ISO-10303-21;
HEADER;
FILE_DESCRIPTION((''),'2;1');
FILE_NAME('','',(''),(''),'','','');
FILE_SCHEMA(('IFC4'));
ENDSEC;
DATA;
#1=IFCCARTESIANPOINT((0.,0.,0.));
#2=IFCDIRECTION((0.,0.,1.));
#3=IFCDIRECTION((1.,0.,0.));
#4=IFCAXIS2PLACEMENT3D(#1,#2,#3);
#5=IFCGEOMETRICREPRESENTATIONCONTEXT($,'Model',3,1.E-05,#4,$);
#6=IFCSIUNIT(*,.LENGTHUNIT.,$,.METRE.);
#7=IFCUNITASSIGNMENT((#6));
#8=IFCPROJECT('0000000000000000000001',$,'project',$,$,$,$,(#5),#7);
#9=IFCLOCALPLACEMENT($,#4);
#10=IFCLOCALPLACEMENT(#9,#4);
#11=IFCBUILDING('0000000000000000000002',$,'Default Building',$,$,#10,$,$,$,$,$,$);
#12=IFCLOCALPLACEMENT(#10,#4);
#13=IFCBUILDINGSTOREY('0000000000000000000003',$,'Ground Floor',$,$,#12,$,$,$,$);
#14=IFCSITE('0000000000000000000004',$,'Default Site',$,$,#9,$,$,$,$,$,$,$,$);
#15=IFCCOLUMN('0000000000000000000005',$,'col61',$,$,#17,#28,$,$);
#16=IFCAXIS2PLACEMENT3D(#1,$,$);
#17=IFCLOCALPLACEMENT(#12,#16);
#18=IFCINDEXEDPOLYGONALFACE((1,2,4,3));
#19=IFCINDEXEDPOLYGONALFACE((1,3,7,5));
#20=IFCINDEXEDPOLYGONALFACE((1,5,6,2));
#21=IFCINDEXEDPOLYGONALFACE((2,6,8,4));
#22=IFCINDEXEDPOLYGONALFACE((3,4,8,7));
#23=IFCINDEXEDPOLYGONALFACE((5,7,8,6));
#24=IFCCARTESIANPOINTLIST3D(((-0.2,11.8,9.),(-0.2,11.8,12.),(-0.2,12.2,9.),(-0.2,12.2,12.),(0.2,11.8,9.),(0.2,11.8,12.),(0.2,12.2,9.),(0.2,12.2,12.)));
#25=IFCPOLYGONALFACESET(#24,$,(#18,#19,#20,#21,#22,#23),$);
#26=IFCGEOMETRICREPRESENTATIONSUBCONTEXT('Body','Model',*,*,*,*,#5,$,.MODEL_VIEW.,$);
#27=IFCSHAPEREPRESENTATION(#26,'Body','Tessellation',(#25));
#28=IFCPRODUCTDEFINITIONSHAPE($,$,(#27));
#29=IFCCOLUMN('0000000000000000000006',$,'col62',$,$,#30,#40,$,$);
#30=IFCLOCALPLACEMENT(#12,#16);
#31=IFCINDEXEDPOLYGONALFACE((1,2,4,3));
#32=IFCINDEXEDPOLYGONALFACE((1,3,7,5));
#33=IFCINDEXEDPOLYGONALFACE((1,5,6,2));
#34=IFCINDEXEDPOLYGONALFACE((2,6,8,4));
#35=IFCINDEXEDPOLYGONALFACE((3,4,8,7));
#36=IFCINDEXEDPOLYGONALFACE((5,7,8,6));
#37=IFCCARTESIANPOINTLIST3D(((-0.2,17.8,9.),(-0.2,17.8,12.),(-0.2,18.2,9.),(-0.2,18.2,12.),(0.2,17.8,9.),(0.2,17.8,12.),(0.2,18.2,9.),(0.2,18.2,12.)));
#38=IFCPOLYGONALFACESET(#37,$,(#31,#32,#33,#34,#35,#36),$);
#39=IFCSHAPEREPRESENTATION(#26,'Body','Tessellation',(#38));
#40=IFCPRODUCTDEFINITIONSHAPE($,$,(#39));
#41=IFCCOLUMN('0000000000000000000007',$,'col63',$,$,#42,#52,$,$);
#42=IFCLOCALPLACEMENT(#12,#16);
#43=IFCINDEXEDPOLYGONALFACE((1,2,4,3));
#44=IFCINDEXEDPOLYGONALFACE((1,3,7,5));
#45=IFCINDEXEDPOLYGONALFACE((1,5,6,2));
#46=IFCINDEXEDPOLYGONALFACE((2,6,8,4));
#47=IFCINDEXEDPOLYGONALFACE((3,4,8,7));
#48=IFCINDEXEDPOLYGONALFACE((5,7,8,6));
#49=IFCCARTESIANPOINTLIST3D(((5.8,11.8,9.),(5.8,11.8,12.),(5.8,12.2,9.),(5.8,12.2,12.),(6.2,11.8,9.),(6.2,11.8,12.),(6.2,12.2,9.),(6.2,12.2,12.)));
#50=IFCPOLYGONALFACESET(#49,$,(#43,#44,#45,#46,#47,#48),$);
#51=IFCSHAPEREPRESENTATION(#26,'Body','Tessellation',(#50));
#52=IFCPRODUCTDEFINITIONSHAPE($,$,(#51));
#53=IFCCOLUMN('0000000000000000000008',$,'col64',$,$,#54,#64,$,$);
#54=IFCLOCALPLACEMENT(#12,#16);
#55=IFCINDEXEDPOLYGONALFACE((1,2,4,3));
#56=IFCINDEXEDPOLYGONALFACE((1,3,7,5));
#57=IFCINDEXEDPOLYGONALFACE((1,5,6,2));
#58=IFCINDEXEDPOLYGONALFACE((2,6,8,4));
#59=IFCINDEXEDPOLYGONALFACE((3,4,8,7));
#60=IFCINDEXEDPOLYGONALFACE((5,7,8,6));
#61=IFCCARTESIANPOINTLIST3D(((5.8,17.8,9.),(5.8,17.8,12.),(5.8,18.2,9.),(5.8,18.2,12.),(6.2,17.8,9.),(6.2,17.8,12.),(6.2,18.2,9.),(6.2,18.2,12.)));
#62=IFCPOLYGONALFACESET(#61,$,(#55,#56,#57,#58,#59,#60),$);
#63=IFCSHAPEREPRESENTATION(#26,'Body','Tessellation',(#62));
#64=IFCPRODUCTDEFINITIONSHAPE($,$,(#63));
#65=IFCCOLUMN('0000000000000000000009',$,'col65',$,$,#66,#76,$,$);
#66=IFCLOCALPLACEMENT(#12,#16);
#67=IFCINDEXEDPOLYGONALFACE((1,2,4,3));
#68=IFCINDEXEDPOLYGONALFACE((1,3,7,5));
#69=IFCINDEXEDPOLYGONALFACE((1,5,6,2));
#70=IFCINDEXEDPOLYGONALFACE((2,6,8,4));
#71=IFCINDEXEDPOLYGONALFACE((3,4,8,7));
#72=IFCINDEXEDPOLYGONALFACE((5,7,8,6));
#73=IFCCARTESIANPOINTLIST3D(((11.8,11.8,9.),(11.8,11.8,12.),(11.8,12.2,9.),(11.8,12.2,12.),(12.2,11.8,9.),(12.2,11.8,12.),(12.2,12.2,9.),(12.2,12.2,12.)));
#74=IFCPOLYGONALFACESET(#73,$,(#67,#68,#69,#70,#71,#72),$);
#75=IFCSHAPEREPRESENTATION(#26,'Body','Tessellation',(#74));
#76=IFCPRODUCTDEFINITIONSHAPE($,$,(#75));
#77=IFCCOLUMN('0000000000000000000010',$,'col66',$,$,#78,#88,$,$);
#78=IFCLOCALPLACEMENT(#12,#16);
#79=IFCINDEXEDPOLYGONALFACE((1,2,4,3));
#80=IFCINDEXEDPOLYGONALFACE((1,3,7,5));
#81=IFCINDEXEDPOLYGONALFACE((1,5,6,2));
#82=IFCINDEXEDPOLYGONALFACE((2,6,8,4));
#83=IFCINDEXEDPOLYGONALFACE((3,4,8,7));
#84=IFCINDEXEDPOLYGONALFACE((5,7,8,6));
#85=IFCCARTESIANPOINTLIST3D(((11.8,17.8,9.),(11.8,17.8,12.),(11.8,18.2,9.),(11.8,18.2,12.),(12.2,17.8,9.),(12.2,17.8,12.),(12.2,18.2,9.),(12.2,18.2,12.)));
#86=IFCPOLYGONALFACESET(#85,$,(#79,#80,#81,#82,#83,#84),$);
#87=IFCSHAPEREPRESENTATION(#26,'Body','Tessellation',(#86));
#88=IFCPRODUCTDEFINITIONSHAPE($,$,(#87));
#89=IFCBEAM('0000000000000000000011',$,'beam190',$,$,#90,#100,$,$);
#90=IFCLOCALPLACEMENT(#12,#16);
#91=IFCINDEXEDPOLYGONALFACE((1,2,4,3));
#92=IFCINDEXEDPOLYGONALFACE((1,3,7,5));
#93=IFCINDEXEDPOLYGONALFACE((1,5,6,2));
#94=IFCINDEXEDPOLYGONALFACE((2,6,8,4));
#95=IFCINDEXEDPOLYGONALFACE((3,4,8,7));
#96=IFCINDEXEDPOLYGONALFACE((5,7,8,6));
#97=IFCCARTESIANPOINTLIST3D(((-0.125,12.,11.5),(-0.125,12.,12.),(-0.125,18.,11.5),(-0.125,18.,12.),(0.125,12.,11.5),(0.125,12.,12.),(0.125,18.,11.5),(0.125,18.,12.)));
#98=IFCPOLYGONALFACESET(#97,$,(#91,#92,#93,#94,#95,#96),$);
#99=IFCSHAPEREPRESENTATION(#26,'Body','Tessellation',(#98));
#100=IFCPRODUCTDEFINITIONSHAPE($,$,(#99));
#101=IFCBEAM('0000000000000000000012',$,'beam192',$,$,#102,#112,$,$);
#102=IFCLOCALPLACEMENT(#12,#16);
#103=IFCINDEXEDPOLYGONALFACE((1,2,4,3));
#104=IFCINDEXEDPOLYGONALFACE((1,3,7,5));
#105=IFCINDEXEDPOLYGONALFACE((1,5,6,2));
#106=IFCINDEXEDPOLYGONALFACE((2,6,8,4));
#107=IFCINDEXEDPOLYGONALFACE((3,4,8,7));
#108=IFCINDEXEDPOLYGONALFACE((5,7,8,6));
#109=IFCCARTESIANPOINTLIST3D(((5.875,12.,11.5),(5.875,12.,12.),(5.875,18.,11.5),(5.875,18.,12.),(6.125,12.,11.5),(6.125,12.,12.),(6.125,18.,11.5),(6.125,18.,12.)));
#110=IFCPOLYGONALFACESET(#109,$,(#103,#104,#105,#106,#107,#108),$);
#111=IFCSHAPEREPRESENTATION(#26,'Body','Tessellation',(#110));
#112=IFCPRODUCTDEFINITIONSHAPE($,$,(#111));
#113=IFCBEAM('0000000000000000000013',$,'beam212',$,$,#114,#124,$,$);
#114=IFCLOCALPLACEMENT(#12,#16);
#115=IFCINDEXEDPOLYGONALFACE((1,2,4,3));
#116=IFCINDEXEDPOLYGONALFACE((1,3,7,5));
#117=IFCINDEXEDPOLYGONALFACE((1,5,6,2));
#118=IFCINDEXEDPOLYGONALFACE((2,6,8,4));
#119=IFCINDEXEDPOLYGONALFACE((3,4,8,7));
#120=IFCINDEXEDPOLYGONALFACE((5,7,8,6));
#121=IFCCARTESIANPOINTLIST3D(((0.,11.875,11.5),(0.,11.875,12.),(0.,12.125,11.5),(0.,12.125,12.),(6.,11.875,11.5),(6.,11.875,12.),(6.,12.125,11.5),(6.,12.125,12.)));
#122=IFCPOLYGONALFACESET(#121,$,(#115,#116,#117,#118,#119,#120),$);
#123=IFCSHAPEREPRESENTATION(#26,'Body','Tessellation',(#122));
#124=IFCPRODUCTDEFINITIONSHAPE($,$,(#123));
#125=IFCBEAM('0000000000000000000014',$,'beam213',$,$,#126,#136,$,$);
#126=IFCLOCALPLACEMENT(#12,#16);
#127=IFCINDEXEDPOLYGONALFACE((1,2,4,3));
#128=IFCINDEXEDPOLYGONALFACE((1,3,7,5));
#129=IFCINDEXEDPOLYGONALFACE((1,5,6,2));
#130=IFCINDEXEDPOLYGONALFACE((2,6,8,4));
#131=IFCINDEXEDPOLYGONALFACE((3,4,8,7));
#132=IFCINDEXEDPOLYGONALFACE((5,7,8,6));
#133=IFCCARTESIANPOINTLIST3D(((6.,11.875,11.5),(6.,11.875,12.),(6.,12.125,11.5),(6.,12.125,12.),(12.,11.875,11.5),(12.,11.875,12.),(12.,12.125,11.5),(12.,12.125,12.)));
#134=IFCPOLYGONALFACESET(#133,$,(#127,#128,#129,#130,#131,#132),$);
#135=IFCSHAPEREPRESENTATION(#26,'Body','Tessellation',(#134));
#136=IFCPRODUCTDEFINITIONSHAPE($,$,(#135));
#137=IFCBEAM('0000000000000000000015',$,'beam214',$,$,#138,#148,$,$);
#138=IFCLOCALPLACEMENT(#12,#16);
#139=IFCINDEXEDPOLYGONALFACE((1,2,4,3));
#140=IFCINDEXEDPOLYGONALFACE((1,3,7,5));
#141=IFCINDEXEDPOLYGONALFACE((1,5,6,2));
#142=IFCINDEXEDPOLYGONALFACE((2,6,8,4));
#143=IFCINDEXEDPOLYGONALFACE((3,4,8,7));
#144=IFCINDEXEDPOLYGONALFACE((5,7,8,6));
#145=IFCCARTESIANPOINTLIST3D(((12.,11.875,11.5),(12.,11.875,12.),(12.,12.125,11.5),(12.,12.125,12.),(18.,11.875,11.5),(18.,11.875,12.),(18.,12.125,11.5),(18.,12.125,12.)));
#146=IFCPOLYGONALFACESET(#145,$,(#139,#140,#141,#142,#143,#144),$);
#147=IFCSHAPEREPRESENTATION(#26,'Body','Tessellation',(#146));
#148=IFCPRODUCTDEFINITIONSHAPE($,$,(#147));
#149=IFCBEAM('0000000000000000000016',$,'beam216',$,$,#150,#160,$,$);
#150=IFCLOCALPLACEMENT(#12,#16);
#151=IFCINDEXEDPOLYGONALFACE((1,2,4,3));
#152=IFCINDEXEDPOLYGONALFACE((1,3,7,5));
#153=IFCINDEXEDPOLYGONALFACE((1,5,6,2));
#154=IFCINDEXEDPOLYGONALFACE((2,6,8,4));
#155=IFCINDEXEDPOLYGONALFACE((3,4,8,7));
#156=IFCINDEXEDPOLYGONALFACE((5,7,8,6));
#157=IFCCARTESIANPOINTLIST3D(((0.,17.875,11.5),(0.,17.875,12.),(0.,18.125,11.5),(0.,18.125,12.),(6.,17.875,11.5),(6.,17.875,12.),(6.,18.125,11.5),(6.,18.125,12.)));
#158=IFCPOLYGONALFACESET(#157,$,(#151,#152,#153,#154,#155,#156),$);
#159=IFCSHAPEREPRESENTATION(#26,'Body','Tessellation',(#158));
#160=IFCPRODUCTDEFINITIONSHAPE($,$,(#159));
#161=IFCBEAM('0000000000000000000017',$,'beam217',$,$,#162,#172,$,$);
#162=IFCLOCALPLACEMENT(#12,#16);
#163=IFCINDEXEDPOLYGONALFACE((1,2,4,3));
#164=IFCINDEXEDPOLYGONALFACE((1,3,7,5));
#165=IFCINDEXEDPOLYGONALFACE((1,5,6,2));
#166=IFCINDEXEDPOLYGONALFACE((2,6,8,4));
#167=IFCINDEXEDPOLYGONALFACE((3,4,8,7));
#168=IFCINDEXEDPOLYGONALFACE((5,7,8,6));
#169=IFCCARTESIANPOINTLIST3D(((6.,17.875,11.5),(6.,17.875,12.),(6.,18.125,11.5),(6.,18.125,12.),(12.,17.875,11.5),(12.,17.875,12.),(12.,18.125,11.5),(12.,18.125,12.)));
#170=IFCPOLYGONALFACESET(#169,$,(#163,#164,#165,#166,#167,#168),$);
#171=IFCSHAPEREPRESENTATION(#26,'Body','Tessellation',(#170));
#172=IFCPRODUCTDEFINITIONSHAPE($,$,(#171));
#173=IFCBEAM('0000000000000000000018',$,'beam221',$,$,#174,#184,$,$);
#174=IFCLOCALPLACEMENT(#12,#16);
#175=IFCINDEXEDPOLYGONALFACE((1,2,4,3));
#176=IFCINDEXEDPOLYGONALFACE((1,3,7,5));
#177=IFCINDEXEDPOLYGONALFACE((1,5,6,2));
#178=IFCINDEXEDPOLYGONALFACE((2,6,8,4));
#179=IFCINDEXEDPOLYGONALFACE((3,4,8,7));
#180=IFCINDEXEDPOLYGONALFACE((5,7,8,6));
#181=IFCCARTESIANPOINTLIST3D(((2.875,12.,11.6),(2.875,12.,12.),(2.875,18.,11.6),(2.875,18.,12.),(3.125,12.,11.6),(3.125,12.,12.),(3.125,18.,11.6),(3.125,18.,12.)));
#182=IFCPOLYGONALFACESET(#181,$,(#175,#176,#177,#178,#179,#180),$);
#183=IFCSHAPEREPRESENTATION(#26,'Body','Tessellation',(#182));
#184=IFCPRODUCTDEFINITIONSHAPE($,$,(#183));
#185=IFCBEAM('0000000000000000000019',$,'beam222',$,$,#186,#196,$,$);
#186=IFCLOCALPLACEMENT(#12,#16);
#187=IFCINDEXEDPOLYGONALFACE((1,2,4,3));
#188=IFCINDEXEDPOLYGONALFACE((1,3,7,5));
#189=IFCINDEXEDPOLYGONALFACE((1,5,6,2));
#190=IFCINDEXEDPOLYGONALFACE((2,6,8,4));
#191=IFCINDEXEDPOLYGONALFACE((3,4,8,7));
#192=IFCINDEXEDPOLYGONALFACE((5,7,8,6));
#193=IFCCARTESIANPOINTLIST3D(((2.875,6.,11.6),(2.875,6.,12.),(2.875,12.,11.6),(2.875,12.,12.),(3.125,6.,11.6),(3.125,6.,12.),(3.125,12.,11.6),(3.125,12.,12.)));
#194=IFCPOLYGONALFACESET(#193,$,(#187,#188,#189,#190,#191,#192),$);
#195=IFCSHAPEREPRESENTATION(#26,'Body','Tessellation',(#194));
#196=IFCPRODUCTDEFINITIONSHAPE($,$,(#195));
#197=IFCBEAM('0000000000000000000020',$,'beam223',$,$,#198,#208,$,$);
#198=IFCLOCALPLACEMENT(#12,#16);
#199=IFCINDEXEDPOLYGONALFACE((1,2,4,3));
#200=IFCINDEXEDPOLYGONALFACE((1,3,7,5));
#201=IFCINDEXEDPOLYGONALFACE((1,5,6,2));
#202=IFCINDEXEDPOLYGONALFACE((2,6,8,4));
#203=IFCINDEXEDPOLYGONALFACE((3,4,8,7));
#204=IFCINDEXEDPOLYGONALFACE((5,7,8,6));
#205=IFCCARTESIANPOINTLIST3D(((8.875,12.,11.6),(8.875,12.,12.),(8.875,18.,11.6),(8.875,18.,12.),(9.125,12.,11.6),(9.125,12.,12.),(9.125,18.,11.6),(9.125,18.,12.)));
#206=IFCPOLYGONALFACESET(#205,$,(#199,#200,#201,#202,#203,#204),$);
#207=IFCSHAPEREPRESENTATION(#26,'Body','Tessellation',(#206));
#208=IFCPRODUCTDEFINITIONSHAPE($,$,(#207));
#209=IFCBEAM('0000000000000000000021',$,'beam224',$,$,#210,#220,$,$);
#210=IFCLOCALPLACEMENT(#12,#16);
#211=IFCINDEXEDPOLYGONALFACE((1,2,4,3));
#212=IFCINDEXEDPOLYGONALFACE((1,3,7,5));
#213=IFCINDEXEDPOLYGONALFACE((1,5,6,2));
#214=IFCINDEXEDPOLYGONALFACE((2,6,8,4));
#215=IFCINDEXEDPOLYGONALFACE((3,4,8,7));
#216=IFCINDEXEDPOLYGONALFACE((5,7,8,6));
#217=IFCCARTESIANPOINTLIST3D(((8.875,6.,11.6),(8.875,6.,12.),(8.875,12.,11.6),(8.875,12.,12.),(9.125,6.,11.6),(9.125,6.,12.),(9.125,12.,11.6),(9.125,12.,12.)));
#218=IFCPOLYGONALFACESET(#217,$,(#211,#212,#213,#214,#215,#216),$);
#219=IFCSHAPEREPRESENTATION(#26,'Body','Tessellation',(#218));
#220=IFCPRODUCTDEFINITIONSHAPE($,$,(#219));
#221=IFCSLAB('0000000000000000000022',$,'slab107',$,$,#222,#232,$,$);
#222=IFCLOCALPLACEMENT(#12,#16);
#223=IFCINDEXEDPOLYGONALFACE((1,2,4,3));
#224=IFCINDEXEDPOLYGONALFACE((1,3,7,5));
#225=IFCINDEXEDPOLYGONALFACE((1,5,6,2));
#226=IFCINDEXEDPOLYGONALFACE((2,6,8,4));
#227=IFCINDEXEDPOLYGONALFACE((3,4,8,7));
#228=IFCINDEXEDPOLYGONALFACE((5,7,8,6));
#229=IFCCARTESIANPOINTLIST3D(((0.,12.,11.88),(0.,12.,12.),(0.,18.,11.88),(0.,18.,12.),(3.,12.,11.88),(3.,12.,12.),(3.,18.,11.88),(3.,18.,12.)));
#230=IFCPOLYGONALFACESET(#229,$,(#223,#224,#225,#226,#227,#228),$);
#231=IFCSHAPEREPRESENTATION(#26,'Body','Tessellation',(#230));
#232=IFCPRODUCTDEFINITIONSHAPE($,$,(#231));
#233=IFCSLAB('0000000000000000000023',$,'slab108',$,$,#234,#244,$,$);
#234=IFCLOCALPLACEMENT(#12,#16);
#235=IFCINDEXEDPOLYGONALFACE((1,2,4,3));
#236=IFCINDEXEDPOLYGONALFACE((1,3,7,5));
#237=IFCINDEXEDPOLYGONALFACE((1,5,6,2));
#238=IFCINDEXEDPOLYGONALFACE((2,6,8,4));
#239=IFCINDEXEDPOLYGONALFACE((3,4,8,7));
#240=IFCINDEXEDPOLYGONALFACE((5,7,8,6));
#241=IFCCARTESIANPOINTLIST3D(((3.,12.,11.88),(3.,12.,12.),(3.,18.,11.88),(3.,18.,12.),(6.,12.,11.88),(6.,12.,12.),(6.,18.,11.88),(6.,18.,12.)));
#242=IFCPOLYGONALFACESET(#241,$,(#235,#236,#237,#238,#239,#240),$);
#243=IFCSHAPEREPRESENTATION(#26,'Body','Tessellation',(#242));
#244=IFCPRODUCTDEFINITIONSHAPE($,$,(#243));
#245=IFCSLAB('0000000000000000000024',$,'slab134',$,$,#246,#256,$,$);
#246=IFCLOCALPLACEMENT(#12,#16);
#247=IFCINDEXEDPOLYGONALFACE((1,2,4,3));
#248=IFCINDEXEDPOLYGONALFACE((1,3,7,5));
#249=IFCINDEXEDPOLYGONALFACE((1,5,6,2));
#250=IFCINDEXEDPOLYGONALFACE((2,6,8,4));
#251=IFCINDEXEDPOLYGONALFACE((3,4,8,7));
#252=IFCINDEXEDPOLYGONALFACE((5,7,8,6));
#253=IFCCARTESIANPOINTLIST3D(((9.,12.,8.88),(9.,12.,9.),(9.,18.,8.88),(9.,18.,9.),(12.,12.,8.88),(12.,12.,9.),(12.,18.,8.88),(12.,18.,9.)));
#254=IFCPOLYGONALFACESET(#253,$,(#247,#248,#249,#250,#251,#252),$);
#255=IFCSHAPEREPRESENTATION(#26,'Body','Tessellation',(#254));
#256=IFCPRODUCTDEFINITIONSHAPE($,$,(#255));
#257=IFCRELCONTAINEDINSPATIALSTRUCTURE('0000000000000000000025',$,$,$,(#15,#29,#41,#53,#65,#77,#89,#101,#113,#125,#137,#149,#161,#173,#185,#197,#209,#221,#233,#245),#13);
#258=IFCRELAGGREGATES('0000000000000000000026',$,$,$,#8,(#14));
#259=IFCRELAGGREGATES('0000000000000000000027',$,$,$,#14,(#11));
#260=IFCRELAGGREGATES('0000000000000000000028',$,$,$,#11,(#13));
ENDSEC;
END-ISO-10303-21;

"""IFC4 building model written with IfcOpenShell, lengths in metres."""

from ifc_helpers import new_model, si_unit, frame, origin_with_axes, place, context, subcontext, project, spatial, indexed_curve, outline, extrude, element, save


model = new_model("IFC4")

# Units and contexts
model_context = context("Model", 3, precision=1e-05, world=origin_with_axes())
body_context = subcontext(model_context, "Body", "Model", "MODEL_VIEW")
ifc_project = project(units=[si_unit("LENGTHUNIT", "METRE")], contexts=[model_context])

# Site, building, storey
site_placement = place(None, origin_with_axes())
site = spatial("IfcSite", under=ifc_project, at=site_placement, Name="Default Site")
building_placement = place(site_placement, origin_with_axes())
building = spatial("IfcBuilding", under=site, at=building_placement, Name="Default Building")
storey_placement = place(building_placement, origin_with_axes())
storey = spatial("IfcBuildingStorey", under=building, at=storey_placement, Name="Ground Floor")

# Columns
for number, where, z_axis, x_axis, name in (
    (1, (-0.2, 11.8, 9.0), (0.0, 0.0, 1.0), (1.0, 0.0, 0.0), "col61"),
    (2, (-0.2, 17.8, 9.0), (0.0, 0.0, 1.0), (1.0, 0.0, 0.0), "col62"),
    (3, (5.8, 11.8, 9.0), (0.0, 0.0, 1.0), (1.0, 0.0, 0.0), "col63"),
    (4, (5.8, 17.8, 9.0), (0.0, 0.0, 1.0), (1.0, 0.0, 0.0), "col64"),
    (5, (11.8, 11.8, 9.0), (0.0, 0.0, 1.0), (1.0, 0.0, 0.0), "col65"),
    (6, (11.8, 17.8, 9.0), (0.0, 0.0, 1.0), (1.0, 0.0, 0.0), "col66"),
):
    element("IfcColumn", number, at=place(storey_placement, frame(where, z_axis=z_axis, x_axis=x_axis)), inside=storey, Name=name, context=body_context, shape_type="SweptSolid", body=[
        extrude(outline(indexed_curve([(0.0, 0.0), (0.0, 0.4), (0.4, 0.4), (0.4, 0.0), (0.0, 0.0)], self_intersect=False)), origin_with_axes(), (0.0, 0.0, 1.0), 3.0),
    ])

# Beams
for number, where, z_axis, x_axis, name in (
    (7, (0.125, 12.0, 11.5), (0.0, 0.0, 1.0), (0.0, 1.0, 0.0), "beam190"),
    (8, (6.125, 12.0, 11.5), (0.0, 0.0, 1.0), (0.0, 1.0, 0.0), "beam192"),
    (9, (0.0, 11.875, 11.5), (0.0, 0.0, 1.0), (1.0, 0.0, 0.0), "beam212"),
    (10, (6.0, 11.875, 11.5), (0.0, 0.0, 1.0), (1.0, 0.0, 0.0), "beam213"),
    (11, (12.0, 11.875, 11.5), (0.0, 0.0, 1.0), (1.0, 0.0, 0.0), "beam214"),
    (12, (0.0, 17.875, 11.5), (0.0, 0.0, 1.0), (1.0, 0.0, 0.0), "beam216"),
    (13, (6.0, 17.875, 11.5), (0.0, 0.0, 1.0), (1.0, 0.0, 0.0), "beam217"),
):
    element("IfcBeam", number, at=place(storey_placement, frame(where, z_axis=z_axis, x_axis=x_axis)), inside=storey, Name=name, context=body_context, shape_type="SweptSolid", body=[
        extrude(outline(indexed_curve([(0.0, 0.0), (0.0, 0.25), (6.0, 0.25), (6.0, 0.0), (0.0, 0.0)], self_intersect=False)), origin_with_axes(), (0.0, 0.0, 1.0), 0.5),
    ])
for number, where, z_axis, x_axis, name in (
    (14, (2.875, 18.0, 11.6), (0.0, 0.0, 1.0), (0.0, -1.0, 0.0), "beam221"),
    (15, (2.875, 12.0, 11.6), (0.0, 0.0, 1.0), (0.0, -1.0, 0.0), "beam222"),
    (16, (8.875, 18.0, 11.6), (0.0, 0.0, 1.0), (0.0, -1.0, 0.0), "beam223"),
    (17, (8.875, 12.0, 11.6), (0.0, 0.0, 1.0), (0.0, -1.0, 0.0), "beam224"),
):
    element("IfcBeam", number, at=place(storey_placement, frame(where, z_axis=z_axis, x_axis=x_axis)), inside=storey, Name=name, context=body_context, shape_type="SweptSolid", body=[
        extrude(outline(indexed_curve([(0.0, 0.0), (0.0, 0.25), (6.0, 0.25), (6.0, 0.0), (0.0, 0.0)], self_intersect=False)), origin_with_axes(), (0.0, 0.0, 1.0), 0.4),
    ])

# Slabs
for number, where, z_axis, x_axis, name in (
    (18, (0.0, 12.0, 11.88), (0.0, 0.0, 1.0), (1.0, 0.0, 0.0), "slab107"),
    (19, (3.0, 12.0, 11.88), (0.0, 0.0, 1.0), (1.0, 0.0, 0.0), "slab108"),
    (20, (9.0, 12.0, 8.88), (0.0, 0.0, 1.0), (1.0, 0.0, 0.0), "slab134"),
):
    element("IfcSlab", number, at=place(storey_placement, frame(where, z_axis=z_axis, x_axis=x_axis)), inside=storey, Name=name, context=body_context, shape_type="SweptSolid", body=[
        extrude(outline(indexed_curve([(0.0, 0.0), (0.0, 6.0), (3.0, 6.0), (3.0, 0.0), (0.0, 0.0)], self_intersect=False)), origin_with_axes(), (0.0, 0.0, 1.0), 0.12),
    ])

save(model, "model.ifc")
